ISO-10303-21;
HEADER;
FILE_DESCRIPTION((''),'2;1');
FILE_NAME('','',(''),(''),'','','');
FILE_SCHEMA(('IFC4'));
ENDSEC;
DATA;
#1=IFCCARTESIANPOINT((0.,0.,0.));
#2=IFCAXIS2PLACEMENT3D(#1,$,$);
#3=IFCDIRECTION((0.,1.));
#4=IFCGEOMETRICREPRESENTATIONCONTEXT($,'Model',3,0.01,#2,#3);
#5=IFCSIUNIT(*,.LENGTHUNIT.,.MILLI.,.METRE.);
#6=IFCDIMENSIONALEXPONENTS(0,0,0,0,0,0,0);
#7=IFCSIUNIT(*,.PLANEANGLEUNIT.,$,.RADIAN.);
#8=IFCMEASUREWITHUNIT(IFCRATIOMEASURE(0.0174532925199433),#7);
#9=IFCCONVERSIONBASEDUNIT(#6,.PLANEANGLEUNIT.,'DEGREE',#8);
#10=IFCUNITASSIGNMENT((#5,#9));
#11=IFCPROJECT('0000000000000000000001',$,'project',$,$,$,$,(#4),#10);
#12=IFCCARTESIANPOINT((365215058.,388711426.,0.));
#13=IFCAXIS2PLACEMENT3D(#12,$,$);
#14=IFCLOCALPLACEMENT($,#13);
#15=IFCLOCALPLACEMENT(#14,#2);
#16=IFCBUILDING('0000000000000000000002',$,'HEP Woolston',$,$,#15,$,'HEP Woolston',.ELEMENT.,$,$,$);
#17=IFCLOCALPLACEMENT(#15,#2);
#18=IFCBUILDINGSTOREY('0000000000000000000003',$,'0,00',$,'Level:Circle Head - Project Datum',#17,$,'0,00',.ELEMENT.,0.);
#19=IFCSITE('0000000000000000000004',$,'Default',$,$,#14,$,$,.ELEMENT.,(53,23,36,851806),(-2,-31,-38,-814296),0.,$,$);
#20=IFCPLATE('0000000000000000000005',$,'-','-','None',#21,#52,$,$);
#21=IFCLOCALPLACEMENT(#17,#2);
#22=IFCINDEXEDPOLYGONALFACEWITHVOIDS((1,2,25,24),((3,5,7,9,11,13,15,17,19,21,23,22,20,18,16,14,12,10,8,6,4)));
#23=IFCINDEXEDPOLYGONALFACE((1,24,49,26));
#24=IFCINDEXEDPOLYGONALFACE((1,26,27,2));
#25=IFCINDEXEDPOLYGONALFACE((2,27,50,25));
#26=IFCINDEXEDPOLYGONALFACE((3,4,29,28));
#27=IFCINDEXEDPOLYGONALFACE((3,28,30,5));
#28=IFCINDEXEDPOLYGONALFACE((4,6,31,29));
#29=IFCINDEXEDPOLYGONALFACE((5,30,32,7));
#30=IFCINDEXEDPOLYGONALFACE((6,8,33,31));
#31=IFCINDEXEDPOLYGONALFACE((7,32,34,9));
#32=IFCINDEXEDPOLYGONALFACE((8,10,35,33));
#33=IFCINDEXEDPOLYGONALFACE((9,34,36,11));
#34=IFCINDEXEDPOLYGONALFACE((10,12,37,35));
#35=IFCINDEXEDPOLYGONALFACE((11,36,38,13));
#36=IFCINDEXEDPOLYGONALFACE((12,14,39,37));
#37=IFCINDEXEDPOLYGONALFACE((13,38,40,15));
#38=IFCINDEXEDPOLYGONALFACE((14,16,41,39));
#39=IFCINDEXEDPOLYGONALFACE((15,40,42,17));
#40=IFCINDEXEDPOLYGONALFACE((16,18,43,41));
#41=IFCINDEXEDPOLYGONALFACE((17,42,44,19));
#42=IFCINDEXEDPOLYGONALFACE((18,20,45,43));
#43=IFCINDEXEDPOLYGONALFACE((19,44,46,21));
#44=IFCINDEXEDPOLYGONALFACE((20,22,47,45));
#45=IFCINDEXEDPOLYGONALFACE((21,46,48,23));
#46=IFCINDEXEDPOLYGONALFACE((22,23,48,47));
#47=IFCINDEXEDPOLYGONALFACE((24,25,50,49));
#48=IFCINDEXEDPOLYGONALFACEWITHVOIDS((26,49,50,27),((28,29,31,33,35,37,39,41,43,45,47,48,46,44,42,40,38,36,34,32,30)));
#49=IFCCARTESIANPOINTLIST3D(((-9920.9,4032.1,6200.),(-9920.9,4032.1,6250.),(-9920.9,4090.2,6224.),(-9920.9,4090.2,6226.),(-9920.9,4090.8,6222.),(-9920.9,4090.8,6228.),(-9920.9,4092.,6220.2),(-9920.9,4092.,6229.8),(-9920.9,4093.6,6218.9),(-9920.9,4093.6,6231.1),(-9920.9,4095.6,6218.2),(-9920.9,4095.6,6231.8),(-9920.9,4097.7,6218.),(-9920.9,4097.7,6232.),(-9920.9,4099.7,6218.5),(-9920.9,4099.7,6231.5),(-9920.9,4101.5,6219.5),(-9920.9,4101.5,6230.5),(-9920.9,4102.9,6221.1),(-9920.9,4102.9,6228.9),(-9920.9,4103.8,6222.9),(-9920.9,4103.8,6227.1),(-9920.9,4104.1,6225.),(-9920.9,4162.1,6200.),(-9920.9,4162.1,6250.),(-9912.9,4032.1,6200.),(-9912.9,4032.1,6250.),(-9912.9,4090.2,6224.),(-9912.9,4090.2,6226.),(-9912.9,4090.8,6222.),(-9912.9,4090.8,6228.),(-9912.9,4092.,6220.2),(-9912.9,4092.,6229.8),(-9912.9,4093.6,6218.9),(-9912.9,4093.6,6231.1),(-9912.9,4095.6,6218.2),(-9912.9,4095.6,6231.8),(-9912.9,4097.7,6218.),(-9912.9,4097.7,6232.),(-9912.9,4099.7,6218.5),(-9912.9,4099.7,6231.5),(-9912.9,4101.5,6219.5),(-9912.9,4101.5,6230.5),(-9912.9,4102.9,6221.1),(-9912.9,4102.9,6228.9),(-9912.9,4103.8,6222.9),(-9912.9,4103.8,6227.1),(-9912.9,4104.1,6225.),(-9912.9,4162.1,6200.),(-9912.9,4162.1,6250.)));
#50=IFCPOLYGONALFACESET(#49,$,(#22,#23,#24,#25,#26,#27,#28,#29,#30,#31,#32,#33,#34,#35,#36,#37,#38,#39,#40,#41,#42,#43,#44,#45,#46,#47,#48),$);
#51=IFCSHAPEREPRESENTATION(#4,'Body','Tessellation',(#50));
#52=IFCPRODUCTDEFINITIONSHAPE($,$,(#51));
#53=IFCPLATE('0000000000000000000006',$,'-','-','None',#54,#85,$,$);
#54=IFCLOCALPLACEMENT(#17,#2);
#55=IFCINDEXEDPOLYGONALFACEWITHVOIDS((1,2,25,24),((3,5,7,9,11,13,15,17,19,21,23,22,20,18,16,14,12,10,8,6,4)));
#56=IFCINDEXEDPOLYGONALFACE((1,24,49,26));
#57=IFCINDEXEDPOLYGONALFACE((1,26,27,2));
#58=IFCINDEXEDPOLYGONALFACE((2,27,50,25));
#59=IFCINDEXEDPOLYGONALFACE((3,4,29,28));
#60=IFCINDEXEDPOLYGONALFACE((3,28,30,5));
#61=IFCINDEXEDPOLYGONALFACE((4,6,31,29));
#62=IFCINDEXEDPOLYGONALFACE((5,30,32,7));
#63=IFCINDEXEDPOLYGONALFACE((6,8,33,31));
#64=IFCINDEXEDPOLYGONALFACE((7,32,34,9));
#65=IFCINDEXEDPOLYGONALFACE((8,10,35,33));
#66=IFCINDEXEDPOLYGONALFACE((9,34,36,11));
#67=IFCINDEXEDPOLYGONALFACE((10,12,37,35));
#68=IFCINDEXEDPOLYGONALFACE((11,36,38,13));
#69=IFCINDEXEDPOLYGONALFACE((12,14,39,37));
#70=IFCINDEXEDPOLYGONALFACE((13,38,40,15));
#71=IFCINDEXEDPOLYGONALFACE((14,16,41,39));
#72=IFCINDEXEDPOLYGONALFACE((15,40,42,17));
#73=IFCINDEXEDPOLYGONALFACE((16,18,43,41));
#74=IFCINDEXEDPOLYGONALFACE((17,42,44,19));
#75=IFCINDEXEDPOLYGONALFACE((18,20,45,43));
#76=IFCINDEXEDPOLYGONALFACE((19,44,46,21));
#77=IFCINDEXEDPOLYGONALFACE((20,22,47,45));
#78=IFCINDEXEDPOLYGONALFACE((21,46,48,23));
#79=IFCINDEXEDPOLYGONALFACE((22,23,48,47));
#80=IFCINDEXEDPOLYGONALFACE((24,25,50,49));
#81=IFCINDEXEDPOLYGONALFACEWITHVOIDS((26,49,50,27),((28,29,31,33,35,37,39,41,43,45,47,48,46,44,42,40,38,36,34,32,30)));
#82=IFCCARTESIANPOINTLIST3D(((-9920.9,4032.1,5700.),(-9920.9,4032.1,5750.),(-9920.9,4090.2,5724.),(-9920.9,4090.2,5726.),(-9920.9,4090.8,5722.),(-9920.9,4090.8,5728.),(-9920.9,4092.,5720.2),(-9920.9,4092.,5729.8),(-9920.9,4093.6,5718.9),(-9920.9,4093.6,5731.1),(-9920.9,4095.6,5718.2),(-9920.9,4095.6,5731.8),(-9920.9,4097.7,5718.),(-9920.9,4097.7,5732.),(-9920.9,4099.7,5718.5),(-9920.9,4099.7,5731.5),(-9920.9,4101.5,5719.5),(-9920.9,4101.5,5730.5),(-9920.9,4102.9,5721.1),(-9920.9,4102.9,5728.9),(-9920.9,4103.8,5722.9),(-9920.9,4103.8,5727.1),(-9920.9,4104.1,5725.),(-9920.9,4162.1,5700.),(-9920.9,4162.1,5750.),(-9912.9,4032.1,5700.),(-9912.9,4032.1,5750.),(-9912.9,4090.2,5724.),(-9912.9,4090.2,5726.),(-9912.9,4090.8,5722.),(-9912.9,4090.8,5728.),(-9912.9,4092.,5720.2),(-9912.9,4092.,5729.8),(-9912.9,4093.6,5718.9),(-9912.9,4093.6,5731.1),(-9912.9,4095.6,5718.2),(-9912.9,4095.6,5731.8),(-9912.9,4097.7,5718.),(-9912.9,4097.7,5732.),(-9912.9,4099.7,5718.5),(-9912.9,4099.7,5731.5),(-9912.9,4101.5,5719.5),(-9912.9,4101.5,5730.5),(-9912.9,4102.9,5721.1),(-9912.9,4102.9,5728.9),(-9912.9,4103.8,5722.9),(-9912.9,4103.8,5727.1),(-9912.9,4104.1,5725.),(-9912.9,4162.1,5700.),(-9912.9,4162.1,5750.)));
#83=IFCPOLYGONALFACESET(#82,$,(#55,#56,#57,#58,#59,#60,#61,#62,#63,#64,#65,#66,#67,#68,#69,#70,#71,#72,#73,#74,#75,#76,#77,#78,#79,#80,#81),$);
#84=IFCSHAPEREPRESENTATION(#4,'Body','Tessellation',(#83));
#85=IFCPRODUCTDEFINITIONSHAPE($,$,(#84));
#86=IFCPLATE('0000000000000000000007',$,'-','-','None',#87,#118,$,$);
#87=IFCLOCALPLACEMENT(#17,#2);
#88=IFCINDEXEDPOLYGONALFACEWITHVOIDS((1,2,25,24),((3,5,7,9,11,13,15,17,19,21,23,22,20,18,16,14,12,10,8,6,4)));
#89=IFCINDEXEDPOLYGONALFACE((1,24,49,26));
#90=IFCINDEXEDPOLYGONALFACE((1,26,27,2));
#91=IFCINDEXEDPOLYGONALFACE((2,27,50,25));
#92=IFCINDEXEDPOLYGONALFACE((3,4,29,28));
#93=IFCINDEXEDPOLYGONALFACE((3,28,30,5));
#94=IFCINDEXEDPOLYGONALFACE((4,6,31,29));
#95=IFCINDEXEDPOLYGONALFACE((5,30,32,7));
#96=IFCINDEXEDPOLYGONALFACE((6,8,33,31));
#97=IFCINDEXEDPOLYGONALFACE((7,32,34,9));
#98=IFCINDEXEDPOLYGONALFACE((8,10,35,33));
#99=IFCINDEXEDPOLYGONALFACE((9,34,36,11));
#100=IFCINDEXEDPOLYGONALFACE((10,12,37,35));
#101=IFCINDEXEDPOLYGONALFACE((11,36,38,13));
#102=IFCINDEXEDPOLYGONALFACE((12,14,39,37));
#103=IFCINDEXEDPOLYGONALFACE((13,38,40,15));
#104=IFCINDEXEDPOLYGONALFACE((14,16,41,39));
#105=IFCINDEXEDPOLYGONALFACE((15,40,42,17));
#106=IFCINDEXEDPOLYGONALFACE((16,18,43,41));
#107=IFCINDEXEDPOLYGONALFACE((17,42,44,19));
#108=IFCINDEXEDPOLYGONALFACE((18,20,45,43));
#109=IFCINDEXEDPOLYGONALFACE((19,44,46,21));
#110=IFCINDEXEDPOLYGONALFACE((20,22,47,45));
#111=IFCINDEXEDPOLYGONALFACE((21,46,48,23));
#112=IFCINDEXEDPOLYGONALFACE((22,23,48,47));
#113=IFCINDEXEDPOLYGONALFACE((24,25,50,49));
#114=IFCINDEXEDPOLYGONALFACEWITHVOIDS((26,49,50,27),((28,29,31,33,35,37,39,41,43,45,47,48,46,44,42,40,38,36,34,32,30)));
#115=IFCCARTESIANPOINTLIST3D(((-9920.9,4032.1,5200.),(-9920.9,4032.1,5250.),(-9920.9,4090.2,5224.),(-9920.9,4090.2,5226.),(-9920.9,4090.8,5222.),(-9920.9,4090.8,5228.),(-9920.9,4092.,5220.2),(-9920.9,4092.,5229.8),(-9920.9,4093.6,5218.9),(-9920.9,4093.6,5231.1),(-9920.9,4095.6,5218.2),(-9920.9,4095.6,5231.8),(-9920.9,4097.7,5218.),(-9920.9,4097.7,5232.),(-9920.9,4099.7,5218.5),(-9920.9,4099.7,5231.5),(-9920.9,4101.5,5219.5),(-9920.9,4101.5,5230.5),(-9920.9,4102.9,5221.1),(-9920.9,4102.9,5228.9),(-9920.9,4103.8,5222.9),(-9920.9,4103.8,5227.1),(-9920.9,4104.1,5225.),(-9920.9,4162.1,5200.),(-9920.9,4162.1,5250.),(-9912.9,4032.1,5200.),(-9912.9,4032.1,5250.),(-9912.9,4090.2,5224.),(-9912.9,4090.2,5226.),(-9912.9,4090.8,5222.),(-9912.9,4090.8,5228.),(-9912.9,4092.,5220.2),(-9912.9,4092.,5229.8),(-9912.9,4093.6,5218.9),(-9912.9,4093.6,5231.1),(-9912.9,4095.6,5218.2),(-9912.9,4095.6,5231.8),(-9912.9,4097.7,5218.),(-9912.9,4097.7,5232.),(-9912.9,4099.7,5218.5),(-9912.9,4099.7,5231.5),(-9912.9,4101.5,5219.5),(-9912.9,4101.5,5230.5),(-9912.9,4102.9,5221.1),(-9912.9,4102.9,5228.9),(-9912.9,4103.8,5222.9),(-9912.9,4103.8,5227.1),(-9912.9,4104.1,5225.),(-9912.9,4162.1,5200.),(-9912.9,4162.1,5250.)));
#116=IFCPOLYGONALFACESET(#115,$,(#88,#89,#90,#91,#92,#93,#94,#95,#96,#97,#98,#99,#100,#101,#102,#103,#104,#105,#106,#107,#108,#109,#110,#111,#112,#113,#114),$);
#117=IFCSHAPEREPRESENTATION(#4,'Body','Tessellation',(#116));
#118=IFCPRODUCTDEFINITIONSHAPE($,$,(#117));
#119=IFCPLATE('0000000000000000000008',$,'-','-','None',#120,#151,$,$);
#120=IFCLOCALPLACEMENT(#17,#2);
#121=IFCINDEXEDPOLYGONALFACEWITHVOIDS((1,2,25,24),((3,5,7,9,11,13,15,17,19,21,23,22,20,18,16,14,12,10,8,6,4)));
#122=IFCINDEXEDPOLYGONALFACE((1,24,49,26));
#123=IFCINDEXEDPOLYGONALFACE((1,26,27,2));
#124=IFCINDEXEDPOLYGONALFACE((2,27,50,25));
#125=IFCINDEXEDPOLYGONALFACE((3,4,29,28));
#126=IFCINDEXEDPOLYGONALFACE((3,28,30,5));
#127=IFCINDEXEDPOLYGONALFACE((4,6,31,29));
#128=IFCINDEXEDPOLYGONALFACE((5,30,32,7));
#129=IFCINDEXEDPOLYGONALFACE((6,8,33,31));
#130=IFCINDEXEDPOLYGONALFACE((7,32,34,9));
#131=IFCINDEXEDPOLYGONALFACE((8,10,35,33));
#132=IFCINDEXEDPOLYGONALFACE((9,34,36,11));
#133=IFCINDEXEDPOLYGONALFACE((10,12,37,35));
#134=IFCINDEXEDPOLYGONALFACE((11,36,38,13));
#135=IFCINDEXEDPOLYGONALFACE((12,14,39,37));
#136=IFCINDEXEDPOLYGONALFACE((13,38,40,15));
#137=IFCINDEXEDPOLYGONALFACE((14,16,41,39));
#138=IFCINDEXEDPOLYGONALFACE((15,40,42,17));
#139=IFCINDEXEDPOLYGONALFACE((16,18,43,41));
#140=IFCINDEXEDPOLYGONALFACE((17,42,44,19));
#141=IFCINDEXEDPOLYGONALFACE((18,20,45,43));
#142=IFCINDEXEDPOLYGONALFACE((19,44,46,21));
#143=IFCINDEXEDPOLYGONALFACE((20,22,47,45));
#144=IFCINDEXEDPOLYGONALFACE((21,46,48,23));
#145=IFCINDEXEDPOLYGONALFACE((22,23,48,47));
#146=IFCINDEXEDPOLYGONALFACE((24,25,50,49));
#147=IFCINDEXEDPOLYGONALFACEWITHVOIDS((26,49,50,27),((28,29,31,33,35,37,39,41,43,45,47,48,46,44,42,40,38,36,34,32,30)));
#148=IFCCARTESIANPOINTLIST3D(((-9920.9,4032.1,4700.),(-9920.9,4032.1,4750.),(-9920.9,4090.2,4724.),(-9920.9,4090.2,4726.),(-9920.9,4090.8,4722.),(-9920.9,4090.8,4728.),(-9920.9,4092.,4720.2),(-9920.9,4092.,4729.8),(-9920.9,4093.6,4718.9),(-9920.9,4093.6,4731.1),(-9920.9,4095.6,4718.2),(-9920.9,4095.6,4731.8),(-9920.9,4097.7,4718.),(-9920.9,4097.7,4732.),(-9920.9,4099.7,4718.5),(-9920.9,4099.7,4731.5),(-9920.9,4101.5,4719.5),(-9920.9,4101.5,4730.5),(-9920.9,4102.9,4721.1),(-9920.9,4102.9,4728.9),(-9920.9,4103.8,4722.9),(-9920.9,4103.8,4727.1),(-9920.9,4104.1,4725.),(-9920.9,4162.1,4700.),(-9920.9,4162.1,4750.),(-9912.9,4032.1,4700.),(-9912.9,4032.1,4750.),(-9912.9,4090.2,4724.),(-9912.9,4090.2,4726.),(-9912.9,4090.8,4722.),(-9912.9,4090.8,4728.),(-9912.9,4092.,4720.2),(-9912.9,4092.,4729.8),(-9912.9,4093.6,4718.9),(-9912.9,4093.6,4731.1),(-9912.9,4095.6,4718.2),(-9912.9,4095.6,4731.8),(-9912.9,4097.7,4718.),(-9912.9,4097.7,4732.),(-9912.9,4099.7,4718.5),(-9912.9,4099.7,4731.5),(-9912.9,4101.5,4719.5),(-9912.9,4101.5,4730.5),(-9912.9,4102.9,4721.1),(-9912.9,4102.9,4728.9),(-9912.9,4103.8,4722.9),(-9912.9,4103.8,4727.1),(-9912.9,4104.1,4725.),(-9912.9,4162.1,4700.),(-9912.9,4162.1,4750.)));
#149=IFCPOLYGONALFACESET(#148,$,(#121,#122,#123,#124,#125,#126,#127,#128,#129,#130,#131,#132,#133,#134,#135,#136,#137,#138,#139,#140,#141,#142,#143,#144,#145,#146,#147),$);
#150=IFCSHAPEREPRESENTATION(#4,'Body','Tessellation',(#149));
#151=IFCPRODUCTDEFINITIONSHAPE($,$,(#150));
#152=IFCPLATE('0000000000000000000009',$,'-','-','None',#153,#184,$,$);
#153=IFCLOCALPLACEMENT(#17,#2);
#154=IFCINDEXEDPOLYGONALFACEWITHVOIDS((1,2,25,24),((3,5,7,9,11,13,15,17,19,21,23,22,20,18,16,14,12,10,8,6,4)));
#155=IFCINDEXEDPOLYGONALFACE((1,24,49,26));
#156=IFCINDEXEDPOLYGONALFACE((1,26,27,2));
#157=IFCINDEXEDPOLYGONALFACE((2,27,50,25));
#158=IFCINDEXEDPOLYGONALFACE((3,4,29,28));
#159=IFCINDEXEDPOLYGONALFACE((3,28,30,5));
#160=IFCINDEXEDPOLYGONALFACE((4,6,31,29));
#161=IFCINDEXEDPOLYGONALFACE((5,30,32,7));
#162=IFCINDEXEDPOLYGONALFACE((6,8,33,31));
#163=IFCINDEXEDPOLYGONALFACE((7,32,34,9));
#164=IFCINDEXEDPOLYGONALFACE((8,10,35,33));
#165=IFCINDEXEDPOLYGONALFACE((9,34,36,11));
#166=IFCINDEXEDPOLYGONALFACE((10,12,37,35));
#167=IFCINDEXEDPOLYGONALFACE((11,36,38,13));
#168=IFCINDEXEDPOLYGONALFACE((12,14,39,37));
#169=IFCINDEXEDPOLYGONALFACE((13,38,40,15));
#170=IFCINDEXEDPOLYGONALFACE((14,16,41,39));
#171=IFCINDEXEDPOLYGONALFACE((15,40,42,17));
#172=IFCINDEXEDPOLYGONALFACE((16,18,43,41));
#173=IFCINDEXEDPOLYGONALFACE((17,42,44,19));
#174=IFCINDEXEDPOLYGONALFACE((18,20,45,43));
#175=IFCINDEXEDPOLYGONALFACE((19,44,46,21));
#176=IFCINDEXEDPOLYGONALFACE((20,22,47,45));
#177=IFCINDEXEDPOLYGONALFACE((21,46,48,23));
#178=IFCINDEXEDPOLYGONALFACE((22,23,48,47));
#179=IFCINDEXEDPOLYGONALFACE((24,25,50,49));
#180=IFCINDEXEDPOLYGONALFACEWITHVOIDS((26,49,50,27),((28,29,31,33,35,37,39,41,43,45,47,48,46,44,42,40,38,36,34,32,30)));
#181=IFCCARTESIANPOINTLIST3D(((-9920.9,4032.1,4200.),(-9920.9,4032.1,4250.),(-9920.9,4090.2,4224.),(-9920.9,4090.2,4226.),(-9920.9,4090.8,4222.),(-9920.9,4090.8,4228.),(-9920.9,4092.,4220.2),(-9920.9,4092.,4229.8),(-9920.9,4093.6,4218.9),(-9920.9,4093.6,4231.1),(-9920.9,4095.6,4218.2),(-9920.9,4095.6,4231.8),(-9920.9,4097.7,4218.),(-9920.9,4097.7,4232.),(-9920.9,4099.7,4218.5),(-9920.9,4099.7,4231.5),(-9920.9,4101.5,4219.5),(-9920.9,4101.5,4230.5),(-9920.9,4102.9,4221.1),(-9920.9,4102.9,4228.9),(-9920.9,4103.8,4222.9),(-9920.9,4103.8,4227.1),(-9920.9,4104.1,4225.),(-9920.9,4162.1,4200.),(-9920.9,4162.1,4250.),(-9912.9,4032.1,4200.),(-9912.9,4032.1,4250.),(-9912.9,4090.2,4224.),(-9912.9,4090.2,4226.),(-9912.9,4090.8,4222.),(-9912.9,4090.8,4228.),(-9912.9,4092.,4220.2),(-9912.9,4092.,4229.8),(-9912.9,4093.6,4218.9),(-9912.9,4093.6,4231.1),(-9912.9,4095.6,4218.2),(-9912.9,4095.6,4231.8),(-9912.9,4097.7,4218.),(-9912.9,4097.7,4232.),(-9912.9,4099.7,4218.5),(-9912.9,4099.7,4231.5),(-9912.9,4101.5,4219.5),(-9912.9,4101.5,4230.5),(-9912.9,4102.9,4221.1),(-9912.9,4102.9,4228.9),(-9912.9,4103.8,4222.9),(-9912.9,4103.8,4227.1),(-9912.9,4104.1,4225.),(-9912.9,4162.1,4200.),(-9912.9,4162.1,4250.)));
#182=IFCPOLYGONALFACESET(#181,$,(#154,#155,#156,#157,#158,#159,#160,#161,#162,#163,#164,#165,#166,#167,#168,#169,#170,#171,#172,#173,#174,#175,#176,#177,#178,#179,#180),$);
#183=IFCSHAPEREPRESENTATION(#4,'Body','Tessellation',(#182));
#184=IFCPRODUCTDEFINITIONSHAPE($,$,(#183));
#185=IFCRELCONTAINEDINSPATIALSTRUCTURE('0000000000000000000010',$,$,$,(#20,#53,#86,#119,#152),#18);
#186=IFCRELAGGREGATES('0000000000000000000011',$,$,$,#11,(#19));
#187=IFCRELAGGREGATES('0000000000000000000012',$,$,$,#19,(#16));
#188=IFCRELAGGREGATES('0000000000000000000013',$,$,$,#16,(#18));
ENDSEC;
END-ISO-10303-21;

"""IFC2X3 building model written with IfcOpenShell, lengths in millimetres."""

from ifc_helpers import new_model, entity, si_unit, converted_unit, direction, frame, origin, origin_with_axes, origin_2d_with_axis, place, context, project, spatial, polyline, circle, outline, extrude, element, save


model = new_model("IFC2X3")

# Units and contexts
model_context = context("Model", 3, precision=0.01, world=origin(), true_north=direction((0.0, 1.0)))
ifc_project = project(units=[si_unit("LENGTHUNIT", "METRE", prefix="MILLI"), converted_unit("PLANEANGLEUNIT", "DEGREE", entity("IfcRatioMeasure", 0.0174532925199433), si_unit("PLANEANGLEUNIT", "RADIAN"), dimensions=[0, 0, 0, 0, 0, 0, 0])], contexts=[model_context])

# Site, building, storey
site_placement = place(None, frame((365215058.0, 388711426.0, 0.0)))
site = spatial("IfcSite", under=ifc_project, at=site_placement, Name="Default", CompositionType="ELEMENT", RefLatitude=(53, 23, 36, 851806), RefLongitude=(-2, -31, -38, -814296), RefElevation=0.0)
building_placement = place(site_placement, origin())
building = spatial("IfcBuilding", under=site, at=building_placement, Name="HEP Woolston", LongName="HEP Woolston", CompositionType="ELEMENT")
storey_placement = place(building_placement, origin())
storey = spatial("IfcBuildingStorey", under=building, at=storey_placement, Name="0,00", ObjectType="Level:Circle Head - Project Datum", LongName="0,00", CompositionType="ELEMENT", Elevation=0.0)

# Plates, openings
plate_1_placement = place(storey_placement, frame((-9920.9, 4032.1, 6250.0), z_axis=(1.0, 0.0, 0.0), x_axis=(0.0, 1.0, 0.0)))
plate_1 = element("IfcPlate", 1, at=plate_1_placement, inside=storey, Name="-", Description="-", ObjectType="None", context=model_context, shape_type="SweptSolid", body=[
    extrude(outline(polyline([(0.0, -50.0), (130.0, -50.0), (130.0, 0.0), (0.0, 0.0), (0.0, -50.0)])), origin_with_axes(), (0.0, 0.0, 1.0), 8.0),
])
opening_1_placement = place(plate_1_placement, frame((65.0, -25.0, 8.5), z_axis=(0.0, 0.0, -1.0), x_axis=(1.0, 0.0, 0.0)))
element("IfcOpeningElement", 2, at=opening_1_placement, cuts=plate_1, ObjectType="Opening", context=model_context, shape_type="SweptSolid", body=[
    extrude(circle(Radius=7.0, at=origin_2d_with_axis()), origin(), (0.0, 0.0, 1.0), 9.0),
])
plate_2_placement = place(storey_placement, frame((-9920.9, 4032.1, 5750.0), z_axis=(1.0, 0.0, 0.0), x_axis=(0.0, 1.0, 0.0)))
plate_2 = element("IfcPlate", 3, at=plate_2_placement, inside=storey, Name="-", Description="-", ObjectType="None", context=model_context, shape_type="SweptSolid", body=[
    extrude(outline(polyline([(0.0, -50.0), (130.0, -50.0), (130.0, 0.0), (0.0, 0.0), (0.0, -50.0)])), origin_with_axes(), (0.0, 0.0, 1.0), 8.0),
])
opening_2_placement = place(plate_2_placement, frame((65.0, -25.0, 8.5), z_axis=(0.0, 0.0, -1.0), x_axis=(1.0, 0.0, 0.0)))
element("IfcOpeningElement", 4, at=opening_2_placement, cuts=plate_2, ObjectType="Opening", context=model_context, shape_type="SweptSolid", body=[
    extrude(circle(Radius=7.0, at=origin_2d_with_axis()), origin(), (0.0, 0.0, 1.0), 9.0),
])
plate_3_placement = place(storey_placement, frame((-9920.9, 4032.1, 5250.0), z_axis=(1.0, 0.0, 0.0), x_axis=(0.0, 1.0, 0.0)))
plate_3 = element("IfcPlate", 5, at=plate_3_placement, inside=storey, Name="-", Description="-", ObjectType="None", context=model_context, shape_type="SweptSolid", body=[
    extrude(outline(polyline([(0.0, -50.0), (130.0, -50.0), (130.0, 0.0), (0.0, 0.0), (0.0, -50.0)])), origin_with_axes(), (0.0, 0.0, 1.0), 8.0),
])
opening_3_placement = place(plate_3_placement, frame((65.0, -25.0, 8.5), z_axis=(0.0, 0.0, -1.0), x_axis=(1.0, 0.0, 0.0)))
element("IfcOpeningElement", 6, at=opening_3_placement, cuts=plate_3, ObjectType="Opening", context=model_context, shape_type="SweptSolid", body=[
    extrude(circle(Radius=7.0, at=origin_2d_with_axis()), origin(), (0.0, 0.0, 1.0), 9.0),
])
plate_4_placement = place(storey_placement, frame((-9920.9, 4032.1, 4750.0), z_axis=(1.0, 0.0, 0.0), x_axis=(0.0, 1.0, 0.0)))
plate_4 = element("IfcPlate", 7, at=plate_4_placement, inside=storey, Name="-", Description="-", ObjectType="None", context=model_context, shape_type="SweptSolid", body=[
    extrude(outline(polyline([(0.0, -50.0), (130.0, -50.0), (130.0, 0.0), (0.0, 0.0), (0.0, -50.0)])), origin_with_axes(), (0.0, 0.0, 1.0), 8.0),
])
opening_4_placement = place(plate_4_placement, frame((65.0, -25.0, 8.5), z_axis=(0.0, 0.0, -1.0), x_axis=(1.0, 0.0, 0.0)))
element("IfcOpeningElement", 8, at=opening_4_placement, cuts=plate_4, ObjectType="Opening", context=model_context, shape_type="SweptSolid", body=[
    extrude(circle(Radius=7.0, at=origin_2d_with_axis()), origin(), (0.0, 0.0, 1.0), 9.0),
])
plate_5_placement = place(storey_placement, frame((-9920.9, 4032.1, 4250.0), z_axis=(1.0, 0.0, 0.0), x_axis=(0.0, 1.0, 0.0)))
plate_5 = element("IfcPlate", 9, at=plate_5_placement, inside=storey, Name="-", Description="-", ObjectType="None", context=model_context, shape_type="SweptSolid", body=[
    extrude(outline(polyline([(0.0, -50.0), (130.0, -50.0), (130.0, 0.0), (0.0, 0.0), (0.0, -50.0)])), origin_with_axes(), (0.0, 0.0, 1.0), 8.0),
])
opening_5_placement = place(plate_5_placement, frame((65.0, -25.0, 8.5), z_axis=(0.0, 0.0, -1.0), x_axis=(1.0, 0.0, 0.0)))
element("IfcOpeningElement", 10, at=opening_5_placement, cuts=plate_5, ObjectType="Opening", context=model_context, shape_type="SweptSolid", body=[
    extrude(circle(Radius=7.0, at=origin_2d_with_axis()), origin(), (0.0, 0.0, 1.0), 9.0),
])

save(model, "model.ifc")
